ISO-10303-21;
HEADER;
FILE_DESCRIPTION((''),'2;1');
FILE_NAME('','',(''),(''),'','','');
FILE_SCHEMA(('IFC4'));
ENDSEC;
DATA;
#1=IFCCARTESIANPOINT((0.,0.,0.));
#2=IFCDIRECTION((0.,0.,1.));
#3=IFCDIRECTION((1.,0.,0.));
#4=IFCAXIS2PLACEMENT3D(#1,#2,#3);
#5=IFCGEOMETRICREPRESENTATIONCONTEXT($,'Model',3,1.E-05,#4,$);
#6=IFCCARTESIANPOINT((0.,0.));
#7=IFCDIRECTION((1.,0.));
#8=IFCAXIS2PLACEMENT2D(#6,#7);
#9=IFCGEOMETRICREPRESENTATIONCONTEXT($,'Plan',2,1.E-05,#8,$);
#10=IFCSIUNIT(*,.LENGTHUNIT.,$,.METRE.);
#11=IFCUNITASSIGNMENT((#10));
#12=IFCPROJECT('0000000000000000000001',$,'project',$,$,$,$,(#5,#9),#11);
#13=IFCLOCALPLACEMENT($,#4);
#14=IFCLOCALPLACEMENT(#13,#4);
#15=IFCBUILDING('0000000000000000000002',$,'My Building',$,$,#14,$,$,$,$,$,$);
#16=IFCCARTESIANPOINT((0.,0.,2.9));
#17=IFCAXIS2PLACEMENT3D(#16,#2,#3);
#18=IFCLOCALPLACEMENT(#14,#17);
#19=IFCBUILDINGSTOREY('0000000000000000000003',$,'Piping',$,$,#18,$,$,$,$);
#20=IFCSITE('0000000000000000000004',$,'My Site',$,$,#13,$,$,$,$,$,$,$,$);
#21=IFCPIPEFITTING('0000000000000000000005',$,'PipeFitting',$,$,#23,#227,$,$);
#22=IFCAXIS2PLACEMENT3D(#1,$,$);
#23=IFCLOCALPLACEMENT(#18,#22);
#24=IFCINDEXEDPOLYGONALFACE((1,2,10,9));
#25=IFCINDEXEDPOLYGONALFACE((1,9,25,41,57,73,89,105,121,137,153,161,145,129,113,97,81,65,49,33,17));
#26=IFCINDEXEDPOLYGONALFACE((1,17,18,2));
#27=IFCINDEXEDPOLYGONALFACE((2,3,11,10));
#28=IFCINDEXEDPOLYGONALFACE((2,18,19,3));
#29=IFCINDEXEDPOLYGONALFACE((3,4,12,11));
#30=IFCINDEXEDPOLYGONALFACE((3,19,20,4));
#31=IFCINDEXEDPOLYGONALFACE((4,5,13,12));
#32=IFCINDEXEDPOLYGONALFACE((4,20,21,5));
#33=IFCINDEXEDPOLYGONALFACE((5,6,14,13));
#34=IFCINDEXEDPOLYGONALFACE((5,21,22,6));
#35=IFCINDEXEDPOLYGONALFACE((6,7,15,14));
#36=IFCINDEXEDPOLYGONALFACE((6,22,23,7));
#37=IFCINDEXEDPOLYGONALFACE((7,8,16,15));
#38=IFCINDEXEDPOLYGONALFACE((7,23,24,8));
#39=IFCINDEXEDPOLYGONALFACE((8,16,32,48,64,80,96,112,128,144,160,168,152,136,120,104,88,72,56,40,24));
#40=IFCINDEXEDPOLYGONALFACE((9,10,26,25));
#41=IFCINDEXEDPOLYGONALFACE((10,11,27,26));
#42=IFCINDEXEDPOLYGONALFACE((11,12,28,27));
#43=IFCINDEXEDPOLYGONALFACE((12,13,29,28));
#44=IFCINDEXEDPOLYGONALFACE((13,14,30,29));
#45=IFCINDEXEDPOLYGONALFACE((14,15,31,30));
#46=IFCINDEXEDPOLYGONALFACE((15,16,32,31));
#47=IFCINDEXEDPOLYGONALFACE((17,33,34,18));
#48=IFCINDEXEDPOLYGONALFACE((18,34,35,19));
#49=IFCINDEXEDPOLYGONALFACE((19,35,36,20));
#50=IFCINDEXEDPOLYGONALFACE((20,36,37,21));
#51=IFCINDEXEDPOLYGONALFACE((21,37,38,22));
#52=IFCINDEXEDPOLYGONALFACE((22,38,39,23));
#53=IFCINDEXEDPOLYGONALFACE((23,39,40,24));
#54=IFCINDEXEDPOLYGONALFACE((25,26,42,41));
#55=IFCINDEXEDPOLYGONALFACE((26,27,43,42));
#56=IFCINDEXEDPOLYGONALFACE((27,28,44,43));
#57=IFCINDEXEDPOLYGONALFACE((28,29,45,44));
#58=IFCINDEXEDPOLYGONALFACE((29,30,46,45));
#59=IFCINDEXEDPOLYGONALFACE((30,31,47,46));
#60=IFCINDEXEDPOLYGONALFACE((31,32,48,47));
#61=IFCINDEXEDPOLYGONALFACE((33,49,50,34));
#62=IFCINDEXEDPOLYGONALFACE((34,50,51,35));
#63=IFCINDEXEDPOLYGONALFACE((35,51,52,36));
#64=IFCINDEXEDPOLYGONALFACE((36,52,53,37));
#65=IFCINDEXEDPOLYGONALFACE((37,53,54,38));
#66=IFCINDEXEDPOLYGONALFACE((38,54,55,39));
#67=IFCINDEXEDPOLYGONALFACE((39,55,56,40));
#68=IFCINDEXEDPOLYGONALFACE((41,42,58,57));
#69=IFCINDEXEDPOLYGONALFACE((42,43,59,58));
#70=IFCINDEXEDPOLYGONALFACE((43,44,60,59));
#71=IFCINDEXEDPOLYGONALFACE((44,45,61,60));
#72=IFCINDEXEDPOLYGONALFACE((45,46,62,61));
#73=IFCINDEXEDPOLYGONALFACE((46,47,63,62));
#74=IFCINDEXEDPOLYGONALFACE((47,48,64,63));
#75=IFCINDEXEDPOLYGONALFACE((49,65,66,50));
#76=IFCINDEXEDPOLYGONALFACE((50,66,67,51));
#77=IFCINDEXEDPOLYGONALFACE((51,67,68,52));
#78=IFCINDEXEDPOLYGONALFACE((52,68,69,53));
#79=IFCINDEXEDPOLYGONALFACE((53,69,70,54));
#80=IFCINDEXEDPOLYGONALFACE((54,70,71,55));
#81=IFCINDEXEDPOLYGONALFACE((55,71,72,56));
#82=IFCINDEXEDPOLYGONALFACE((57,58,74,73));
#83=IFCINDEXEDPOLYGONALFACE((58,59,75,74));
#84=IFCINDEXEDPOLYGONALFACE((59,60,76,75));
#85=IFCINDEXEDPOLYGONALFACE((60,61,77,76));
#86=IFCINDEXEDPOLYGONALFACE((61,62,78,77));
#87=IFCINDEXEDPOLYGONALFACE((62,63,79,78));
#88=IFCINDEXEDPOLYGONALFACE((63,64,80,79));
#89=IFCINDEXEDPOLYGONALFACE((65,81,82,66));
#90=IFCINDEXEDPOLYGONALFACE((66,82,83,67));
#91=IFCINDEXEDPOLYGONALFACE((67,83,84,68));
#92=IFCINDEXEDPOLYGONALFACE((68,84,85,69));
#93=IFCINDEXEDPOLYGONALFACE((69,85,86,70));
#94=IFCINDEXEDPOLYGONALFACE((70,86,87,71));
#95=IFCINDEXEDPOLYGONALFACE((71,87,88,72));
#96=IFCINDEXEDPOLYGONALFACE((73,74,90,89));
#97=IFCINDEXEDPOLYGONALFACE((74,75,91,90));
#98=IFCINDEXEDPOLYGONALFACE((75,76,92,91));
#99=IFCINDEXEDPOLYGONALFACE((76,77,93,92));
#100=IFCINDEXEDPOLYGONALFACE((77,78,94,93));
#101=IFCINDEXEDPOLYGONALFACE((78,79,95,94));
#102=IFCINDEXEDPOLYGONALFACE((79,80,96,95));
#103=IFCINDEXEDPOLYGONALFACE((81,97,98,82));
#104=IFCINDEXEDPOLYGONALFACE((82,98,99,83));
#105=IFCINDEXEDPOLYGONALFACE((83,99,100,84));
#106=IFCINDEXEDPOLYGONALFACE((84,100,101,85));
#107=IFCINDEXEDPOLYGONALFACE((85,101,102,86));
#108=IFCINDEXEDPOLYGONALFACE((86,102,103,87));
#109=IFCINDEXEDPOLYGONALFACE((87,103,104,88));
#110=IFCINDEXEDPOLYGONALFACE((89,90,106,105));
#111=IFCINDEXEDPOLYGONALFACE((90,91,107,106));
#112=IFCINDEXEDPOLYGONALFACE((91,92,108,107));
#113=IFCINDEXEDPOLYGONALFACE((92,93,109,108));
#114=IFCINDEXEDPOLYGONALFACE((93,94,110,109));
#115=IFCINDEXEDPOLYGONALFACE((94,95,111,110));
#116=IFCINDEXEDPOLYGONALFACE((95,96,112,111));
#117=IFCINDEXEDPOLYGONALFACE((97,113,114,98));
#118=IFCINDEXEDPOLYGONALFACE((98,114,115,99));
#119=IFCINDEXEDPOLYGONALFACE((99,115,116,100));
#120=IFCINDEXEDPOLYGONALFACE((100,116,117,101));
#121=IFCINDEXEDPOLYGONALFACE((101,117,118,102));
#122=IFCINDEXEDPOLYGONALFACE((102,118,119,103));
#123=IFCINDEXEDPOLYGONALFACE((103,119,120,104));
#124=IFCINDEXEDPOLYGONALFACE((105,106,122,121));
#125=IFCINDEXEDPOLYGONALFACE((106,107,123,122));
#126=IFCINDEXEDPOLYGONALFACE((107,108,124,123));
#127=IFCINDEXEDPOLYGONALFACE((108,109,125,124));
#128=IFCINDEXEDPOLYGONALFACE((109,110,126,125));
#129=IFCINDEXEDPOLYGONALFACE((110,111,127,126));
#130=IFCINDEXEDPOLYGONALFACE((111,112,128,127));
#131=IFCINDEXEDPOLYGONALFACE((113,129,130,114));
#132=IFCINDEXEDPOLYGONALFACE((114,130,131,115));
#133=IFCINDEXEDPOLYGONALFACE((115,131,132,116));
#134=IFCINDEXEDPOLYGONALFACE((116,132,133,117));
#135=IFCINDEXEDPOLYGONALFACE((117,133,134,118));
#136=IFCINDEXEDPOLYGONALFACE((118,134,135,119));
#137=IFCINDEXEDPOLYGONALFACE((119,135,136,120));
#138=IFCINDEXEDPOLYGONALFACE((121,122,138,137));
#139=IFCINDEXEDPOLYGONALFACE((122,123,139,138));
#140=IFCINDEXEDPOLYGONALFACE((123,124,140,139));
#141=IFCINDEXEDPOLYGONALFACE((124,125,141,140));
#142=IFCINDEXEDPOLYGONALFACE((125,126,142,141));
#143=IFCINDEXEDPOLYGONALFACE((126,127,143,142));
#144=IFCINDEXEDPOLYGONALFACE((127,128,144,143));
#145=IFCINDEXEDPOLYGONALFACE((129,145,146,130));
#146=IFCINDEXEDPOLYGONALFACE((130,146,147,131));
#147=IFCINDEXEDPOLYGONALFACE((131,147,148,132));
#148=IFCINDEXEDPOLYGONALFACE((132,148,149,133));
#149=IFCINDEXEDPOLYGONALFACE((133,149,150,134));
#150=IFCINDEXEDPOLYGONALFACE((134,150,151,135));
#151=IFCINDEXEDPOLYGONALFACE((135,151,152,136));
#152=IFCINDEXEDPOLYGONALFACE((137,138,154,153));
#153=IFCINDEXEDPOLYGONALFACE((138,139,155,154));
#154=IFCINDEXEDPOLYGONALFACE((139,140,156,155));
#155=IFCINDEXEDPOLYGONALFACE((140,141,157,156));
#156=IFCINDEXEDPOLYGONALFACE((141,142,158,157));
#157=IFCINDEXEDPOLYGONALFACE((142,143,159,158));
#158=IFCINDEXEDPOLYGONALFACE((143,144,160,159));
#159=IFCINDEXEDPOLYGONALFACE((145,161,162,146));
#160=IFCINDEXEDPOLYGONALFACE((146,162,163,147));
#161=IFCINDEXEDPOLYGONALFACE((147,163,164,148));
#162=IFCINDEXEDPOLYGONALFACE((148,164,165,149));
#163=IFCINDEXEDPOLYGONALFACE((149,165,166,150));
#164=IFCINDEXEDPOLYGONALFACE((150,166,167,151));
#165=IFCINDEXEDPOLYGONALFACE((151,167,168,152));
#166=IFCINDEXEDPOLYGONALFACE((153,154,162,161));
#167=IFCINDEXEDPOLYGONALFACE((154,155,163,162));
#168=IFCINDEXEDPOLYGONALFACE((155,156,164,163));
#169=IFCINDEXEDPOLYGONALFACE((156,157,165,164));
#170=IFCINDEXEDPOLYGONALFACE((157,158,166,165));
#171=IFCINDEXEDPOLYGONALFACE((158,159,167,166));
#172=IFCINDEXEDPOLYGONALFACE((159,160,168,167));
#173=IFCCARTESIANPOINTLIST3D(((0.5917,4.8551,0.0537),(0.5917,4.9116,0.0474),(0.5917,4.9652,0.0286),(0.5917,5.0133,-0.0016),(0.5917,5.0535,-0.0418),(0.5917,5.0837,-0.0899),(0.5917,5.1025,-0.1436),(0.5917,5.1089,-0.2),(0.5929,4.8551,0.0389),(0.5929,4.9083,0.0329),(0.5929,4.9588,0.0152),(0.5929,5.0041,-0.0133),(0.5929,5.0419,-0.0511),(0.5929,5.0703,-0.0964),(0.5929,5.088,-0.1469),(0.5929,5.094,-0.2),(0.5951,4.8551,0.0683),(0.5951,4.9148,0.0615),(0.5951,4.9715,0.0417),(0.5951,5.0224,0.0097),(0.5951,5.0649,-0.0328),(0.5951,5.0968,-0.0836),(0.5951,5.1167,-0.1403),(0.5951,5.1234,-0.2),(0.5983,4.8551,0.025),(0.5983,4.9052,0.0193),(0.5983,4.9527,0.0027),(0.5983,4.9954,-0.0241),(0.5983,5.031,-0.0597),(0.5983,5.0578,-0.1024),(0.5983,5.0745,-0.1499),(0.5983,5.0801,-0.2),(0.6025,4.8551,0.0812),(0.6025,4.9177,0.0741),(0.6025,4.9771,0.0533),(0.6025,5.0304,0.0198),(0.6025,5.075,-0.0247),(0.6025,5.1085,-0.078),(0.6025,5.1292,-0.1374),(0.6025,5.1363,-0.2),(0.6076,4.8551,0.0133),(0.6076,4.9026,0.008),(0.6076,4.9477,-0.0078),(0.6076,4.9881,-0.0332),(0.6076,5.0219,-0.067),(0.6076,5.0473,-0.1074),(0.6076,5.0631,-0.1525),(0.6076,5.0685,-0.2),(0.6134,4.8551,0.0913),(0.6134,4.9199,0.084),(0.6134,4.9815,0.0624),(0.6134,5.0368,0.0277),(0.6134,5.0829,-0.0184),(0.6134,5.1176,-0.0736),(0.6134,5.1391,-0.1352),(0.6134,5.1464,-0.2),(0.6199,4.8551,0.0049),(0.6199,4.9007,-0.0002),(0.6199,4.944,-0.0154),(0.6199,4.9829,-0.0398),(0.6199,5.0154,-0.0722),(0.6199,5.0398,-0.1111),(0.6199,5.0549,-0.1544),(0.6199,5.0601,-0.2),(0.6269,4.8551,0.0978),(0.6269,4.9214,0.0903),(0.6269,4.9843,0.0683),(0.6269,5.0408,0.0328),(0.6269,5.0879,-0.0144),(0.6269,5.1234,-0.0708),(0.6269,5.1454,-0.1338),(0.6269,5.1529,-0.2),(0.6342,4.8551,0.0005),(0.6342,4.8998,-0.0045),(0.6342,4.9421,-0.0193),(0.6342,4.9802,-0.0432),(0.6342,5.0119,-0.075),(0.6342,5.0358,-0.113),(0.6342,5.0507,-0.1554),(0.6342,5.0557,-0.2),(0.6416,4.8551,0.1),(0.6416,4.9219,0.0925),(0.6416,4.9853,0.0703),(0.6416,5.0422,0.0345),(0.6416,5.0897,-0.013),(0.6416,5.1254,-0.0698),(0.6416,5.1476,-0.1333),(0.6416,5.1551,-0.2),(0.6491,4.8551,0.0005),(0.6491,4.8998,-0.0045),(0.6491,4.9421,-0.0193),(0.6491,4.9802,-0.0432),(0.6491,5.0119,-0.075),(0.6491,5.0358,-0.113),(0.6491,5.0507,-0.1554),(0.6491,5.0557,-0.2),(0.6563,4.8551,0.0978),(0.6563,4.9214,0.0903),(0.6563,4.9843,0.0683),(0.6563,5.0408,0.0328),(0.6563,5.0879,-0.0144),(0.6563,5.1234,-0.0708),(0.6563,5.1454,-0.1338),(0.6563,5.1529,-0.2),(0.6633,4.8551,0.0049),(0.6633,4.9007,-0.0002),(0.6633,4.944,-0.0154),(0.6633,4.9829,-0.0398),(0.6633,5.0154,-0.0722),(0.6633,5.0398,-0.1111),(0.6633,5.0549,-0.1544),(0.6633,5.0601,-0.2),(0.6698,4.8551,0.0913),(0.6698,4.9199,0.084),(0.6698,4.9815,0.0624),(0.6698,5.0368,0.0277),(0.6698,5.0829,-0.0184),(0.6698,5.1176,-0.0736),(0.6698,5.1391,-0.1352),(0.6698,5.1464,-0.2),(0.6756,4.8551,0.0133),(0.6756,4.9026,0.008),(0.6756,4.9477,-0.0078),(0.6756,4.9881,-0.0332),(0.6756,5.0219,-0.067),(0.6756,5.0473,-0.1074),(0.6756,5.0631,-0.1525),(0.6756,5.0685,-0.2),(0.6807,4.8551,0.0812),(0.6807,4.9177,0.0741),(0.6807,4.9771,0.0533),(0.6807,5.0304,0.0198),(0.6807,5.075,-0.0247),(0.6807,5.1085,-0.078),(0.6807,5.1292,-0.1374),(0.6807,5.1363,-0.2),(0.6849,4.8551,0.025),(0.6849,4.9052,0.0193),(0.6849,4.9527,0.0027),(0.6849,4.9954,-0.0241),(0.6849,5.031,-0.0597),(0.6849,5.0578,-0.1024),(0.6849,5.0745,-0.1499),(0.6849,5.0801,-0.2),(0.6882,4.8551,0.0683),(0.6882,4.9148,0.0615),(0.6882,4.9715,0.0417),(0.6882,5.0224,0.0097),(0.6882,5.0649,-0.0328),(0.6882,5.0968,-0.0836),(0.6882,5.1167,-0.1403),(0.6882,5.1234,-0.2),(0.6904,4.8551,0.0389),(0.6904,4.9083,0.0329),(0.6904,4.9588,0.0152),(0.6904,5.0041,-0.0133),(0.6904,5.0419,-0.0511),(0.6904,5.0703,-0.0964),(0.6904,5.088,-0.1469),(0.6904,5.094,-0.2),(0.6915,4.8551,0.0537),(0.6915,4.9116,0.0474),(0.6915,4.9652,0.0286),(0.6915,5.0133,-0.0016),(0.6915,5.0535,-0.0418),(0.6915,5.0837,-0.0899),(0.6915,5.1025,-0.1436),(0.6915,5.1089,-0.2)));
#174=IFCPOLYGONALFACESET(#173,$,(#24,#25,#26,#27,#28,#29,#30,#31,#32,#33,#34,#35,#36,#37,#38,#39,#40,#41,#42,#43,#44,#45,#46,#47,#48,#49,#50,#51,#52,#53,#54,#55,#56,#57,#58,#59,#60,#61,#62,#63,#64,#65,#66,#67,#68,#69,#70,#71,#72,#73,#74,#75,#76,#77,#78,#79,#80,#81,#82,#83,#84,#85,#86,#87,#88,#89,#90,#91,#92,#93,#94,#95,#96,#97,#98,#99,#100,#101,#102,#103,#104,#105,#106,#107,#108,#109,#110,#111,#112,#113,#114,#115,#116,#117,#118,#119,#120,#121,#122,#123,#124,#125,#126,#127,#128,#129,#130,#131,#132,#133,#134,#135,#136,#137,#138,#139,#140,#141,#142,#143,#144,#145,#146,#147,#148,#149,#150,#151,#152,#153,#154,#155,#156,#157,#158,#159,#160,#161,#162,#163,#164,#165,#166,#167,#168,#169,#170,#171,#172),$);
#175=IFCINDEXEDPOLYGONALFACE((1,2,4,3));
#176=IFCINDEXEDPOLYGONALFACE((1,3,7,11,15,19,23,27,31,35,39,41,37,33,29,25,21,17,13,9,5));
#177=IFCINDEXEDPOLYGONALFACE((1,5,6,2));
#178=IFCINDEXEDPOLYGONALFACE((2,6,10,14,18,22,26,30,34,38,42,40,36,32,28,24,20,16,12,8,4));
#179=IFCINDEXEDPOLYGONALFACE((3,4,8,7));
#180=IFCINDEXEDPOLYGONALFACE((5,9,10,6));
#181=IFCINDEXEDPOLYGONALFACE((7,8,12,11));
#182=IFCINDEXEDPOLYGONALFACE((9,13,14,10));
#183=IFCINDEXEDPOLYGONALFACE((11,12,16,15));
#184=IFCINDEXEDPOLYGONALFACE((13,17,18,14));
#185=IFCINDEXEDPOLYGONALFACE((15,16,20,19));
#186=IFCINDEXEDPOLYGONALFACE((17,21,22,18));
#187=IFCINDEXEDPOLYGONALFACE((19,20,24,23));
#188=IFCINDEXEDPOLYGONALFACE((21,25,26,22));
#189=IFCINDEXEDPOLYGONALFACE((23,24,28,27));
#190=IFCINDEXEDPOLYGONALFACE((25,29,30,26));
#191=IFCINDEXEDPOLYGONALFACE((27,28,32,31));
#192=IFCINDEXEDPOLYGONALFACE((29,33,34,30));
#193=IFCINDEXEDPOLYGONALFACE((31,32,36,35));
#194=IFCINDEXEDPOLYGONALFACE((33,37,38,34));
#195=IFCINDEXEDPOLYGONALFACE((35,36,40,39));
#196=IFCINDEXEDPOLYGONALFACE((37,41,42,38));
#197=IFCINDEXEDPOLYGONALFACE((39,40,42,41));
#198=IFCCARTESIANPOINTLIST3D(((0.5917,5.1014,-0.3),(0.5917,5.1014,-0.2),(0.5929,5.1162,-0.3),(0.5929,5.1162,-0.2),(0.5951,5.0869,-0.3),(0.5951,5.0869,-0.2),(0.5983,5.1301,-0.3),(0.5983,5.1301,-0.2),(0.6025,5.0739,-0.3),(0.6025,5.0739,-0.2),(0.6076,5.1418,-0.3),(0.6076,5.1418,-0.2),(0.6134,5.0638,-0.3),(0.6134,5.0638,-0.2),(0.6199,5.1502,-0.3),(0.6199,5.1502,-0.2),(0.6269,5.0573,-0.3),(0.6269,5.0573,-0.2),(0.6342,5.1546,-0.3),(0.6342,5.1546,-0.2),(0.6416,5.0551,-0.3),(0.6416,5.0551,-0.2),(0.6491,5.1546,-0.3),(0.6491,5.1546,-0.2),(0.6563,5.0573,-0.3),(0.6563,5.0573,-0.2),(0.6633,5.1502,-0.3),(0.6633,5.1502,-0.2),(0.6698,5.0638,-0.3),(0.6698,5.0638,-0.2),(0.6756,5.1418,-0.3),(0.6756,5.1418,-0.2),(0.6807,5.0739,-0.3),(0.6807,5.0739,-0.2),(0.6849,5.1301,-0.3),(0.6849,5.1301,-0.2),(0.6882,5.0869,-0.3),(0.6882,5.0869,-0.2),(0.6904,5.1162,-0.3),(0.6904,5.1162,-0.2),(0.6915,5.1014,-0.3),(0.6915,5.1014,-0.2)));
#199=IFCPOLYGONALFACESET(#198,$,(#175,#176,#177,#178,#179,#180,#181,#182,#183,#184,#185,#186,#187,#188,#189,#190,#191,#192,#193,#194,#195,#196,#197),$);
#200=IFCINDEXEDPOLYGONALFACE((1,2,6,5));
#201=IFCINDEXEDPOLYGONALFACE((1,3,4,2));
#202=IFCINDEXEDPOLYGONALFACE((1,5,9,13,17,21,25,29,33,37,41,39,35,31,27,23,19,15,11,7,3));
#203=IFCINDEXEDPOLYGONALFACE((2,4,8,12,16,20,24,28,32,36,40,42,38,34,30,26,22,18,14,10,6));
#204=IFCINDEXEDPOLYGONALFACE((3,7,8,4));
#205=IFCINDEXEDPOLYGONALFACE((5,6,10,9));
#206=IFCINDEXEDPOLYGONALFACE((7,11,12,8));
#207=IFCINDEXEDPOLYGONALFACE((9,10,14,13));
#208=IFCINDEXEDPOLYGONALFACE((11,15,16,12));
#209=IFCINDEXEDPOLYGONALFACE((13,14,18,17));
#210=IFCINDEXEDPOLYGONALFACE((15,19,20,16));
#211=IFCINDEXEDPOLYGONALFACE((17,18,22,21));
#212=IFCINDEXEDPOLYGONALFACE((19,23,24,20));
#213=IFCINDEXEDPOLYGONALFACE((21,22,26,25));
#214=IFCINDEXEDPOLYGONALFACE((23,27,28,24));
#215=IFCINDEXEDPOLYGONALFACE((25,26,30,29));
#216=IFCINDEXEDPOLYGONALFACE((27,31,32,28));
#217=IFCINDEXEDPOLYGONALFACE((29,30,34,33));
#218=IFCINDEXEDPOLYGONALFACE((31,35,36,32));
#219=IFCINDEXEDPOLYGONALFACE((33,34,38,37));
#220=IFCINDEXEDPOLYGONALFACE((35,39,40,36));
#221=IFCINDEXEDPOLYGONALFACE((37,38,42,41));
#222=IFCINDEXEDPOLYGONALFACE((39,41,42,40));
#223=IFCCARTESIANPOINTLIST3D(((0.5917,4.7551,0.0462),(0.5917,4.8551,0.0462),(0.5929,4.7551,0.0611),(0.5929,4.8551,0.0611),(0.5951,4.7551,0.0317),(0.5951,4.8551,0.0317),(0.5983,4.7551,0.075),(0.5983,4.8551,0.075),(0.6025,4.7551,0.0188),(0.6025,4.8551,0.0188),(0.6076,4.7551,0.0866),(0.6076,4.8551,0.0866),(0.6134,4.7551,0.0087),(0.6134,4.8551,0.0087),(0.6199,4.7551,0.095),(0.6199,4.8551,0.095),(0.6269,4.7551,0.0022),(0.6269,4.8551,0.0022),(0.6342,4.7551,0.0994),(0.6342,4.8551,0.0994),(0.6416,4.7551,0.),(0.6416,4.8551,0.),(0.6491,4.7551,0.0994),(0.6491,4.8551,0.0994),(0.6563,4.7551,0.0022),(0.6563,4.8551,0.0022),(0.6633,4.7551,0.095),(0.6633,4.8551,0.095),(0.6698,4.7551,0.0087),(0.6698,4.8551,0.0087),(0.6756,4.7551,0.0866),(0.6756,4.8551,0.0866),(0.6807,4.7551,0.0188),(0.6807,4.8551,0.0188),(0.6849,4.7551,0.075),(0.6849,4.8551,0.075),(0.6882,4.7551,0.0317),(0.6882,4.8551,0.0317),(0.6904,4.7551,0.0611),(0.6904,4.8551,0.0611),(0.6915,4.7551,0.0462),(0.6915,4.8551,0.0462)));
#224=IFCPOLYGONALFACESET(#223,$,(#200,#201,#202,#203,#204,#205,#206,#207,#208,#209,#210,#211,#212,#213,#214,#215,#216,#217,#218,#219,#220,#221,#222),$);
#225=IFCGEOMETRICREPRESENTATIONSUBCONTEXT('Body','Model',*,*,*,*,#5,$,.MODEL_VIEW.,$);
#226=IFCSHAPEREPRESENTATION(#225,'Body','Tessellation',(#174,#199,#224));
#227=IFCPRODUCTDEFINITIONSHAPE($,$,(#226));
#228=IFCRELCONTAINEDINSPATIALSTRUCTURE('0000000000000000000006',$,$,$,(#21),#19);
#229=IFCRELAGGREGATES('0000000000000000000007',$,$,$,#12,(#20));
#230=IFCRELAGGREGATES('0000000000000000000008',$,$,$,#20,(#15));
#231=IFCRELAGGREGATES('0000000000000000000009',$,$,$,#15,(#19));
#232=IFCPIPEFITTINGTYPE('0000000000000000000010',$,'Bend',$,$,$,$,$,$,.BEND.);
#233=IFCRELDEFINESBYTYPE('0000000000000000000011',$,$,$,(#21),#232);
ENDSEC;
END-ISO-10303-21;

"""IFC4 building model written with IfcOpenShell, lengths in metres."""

from ifc_helpers import new_model, entity, si_unit, frame, origin_with_axes, origin_2d_with_axis, place, context, subcontext, project, spatial, circle, extrude, source, transform, mapped, type_object, type_shapes, element, save


model = new_model("IFC4")

# Units and contexts
model_context = context("Model", 3, precision=1e-05, world=origin_with_axes())
plan_context = context("Plan", 2, precision=1e-05, world=origin_2d_with_axis())
body_context = subcontext(model_context, "Body", "Model", "MODEL_VIEW")
ifc_project = project(units=[si_unit("LENGTHUNIT", "METRE")], contexts=[model_context, plan_context])

# Site, building, storey
site_placement = place(None, origin_with_axes())
site = spatial("IfcSite", under=ifc_project, at=site_placement, Name="My Site")
building_placement = place(site_placement, origin_with_axes())
building = spatial("IfcBuilding", under=site, at=building_placement, Name="My Building")
storey_placement = place(building_placement, frame((0.0, 0.0, 2.9), z_axis=(0.0, 0.0, 1.0), x_axis=(1.0, 0.0, 0.0)))
storey = spatial("IfcBuildingStorey", under=building, at=storey_placement, Name="Piping")

# Shared definitions
pipe_fitting_type_1 = type_object("IfcPipeFittingType", Name="Bend", PredefinedType="BEND")
shared_shape = source(origin_with_axes(), body_context, "Body", "SolidModel", [
    entity("IfcSweptDiskSolid", entity("IfcIndexedPolyCurve", entity("IfcCartesianPointList3D", [[0.0, 0.0, -0.1], [0.0732, 0.0, -0.2768], [0.25, 0.0, -0.35]]), [entity("IfcArcIndex", [1, 2, 3])]), 0.05),
    extrude(circle(Radius=0.05), origin_with_axes(), (0.0, 0.0, -1.0), 0.1),
    extrude(circle(Radius=0.05), frame((0.25, 0.0, -0.35), z_axis=(1.0, 0.0, 0.0), x_axis=(0.0, 0.0, 1.0)), (0.0, 0.0, 1.0), 0.1),
])
type_shapes(pipe_fitting_type_1, [shared_shape])

# Pipe fitting
for number, where, z_axis, x_axis, name in (
    (1, (0.6416, 5.1051, -0.3), (0.0, 0.0, -1.0), (0.0, -1.0, 0.0), "PipeFitting"),
):
    element("IfcPipeFitting", number, at=place(storey_placement, frame(where, z_axis=z_axis, x_axis=x_axis)), inside=storey, type_object=pipe_fitting_type_1, Name=name, context=body_context, shape_type="MappedRepresentation", body=[
        mapped(shared_shape, transform((0.0, 0.0, 0.0), x_axis=(1.0, 0.0, 0.0), y_axis=(0.0, 1.0, 0.0), z_axis=(0.0, 0.0, 1.0), scale=1.0)),
    ])

save(model, "model.ifc")
